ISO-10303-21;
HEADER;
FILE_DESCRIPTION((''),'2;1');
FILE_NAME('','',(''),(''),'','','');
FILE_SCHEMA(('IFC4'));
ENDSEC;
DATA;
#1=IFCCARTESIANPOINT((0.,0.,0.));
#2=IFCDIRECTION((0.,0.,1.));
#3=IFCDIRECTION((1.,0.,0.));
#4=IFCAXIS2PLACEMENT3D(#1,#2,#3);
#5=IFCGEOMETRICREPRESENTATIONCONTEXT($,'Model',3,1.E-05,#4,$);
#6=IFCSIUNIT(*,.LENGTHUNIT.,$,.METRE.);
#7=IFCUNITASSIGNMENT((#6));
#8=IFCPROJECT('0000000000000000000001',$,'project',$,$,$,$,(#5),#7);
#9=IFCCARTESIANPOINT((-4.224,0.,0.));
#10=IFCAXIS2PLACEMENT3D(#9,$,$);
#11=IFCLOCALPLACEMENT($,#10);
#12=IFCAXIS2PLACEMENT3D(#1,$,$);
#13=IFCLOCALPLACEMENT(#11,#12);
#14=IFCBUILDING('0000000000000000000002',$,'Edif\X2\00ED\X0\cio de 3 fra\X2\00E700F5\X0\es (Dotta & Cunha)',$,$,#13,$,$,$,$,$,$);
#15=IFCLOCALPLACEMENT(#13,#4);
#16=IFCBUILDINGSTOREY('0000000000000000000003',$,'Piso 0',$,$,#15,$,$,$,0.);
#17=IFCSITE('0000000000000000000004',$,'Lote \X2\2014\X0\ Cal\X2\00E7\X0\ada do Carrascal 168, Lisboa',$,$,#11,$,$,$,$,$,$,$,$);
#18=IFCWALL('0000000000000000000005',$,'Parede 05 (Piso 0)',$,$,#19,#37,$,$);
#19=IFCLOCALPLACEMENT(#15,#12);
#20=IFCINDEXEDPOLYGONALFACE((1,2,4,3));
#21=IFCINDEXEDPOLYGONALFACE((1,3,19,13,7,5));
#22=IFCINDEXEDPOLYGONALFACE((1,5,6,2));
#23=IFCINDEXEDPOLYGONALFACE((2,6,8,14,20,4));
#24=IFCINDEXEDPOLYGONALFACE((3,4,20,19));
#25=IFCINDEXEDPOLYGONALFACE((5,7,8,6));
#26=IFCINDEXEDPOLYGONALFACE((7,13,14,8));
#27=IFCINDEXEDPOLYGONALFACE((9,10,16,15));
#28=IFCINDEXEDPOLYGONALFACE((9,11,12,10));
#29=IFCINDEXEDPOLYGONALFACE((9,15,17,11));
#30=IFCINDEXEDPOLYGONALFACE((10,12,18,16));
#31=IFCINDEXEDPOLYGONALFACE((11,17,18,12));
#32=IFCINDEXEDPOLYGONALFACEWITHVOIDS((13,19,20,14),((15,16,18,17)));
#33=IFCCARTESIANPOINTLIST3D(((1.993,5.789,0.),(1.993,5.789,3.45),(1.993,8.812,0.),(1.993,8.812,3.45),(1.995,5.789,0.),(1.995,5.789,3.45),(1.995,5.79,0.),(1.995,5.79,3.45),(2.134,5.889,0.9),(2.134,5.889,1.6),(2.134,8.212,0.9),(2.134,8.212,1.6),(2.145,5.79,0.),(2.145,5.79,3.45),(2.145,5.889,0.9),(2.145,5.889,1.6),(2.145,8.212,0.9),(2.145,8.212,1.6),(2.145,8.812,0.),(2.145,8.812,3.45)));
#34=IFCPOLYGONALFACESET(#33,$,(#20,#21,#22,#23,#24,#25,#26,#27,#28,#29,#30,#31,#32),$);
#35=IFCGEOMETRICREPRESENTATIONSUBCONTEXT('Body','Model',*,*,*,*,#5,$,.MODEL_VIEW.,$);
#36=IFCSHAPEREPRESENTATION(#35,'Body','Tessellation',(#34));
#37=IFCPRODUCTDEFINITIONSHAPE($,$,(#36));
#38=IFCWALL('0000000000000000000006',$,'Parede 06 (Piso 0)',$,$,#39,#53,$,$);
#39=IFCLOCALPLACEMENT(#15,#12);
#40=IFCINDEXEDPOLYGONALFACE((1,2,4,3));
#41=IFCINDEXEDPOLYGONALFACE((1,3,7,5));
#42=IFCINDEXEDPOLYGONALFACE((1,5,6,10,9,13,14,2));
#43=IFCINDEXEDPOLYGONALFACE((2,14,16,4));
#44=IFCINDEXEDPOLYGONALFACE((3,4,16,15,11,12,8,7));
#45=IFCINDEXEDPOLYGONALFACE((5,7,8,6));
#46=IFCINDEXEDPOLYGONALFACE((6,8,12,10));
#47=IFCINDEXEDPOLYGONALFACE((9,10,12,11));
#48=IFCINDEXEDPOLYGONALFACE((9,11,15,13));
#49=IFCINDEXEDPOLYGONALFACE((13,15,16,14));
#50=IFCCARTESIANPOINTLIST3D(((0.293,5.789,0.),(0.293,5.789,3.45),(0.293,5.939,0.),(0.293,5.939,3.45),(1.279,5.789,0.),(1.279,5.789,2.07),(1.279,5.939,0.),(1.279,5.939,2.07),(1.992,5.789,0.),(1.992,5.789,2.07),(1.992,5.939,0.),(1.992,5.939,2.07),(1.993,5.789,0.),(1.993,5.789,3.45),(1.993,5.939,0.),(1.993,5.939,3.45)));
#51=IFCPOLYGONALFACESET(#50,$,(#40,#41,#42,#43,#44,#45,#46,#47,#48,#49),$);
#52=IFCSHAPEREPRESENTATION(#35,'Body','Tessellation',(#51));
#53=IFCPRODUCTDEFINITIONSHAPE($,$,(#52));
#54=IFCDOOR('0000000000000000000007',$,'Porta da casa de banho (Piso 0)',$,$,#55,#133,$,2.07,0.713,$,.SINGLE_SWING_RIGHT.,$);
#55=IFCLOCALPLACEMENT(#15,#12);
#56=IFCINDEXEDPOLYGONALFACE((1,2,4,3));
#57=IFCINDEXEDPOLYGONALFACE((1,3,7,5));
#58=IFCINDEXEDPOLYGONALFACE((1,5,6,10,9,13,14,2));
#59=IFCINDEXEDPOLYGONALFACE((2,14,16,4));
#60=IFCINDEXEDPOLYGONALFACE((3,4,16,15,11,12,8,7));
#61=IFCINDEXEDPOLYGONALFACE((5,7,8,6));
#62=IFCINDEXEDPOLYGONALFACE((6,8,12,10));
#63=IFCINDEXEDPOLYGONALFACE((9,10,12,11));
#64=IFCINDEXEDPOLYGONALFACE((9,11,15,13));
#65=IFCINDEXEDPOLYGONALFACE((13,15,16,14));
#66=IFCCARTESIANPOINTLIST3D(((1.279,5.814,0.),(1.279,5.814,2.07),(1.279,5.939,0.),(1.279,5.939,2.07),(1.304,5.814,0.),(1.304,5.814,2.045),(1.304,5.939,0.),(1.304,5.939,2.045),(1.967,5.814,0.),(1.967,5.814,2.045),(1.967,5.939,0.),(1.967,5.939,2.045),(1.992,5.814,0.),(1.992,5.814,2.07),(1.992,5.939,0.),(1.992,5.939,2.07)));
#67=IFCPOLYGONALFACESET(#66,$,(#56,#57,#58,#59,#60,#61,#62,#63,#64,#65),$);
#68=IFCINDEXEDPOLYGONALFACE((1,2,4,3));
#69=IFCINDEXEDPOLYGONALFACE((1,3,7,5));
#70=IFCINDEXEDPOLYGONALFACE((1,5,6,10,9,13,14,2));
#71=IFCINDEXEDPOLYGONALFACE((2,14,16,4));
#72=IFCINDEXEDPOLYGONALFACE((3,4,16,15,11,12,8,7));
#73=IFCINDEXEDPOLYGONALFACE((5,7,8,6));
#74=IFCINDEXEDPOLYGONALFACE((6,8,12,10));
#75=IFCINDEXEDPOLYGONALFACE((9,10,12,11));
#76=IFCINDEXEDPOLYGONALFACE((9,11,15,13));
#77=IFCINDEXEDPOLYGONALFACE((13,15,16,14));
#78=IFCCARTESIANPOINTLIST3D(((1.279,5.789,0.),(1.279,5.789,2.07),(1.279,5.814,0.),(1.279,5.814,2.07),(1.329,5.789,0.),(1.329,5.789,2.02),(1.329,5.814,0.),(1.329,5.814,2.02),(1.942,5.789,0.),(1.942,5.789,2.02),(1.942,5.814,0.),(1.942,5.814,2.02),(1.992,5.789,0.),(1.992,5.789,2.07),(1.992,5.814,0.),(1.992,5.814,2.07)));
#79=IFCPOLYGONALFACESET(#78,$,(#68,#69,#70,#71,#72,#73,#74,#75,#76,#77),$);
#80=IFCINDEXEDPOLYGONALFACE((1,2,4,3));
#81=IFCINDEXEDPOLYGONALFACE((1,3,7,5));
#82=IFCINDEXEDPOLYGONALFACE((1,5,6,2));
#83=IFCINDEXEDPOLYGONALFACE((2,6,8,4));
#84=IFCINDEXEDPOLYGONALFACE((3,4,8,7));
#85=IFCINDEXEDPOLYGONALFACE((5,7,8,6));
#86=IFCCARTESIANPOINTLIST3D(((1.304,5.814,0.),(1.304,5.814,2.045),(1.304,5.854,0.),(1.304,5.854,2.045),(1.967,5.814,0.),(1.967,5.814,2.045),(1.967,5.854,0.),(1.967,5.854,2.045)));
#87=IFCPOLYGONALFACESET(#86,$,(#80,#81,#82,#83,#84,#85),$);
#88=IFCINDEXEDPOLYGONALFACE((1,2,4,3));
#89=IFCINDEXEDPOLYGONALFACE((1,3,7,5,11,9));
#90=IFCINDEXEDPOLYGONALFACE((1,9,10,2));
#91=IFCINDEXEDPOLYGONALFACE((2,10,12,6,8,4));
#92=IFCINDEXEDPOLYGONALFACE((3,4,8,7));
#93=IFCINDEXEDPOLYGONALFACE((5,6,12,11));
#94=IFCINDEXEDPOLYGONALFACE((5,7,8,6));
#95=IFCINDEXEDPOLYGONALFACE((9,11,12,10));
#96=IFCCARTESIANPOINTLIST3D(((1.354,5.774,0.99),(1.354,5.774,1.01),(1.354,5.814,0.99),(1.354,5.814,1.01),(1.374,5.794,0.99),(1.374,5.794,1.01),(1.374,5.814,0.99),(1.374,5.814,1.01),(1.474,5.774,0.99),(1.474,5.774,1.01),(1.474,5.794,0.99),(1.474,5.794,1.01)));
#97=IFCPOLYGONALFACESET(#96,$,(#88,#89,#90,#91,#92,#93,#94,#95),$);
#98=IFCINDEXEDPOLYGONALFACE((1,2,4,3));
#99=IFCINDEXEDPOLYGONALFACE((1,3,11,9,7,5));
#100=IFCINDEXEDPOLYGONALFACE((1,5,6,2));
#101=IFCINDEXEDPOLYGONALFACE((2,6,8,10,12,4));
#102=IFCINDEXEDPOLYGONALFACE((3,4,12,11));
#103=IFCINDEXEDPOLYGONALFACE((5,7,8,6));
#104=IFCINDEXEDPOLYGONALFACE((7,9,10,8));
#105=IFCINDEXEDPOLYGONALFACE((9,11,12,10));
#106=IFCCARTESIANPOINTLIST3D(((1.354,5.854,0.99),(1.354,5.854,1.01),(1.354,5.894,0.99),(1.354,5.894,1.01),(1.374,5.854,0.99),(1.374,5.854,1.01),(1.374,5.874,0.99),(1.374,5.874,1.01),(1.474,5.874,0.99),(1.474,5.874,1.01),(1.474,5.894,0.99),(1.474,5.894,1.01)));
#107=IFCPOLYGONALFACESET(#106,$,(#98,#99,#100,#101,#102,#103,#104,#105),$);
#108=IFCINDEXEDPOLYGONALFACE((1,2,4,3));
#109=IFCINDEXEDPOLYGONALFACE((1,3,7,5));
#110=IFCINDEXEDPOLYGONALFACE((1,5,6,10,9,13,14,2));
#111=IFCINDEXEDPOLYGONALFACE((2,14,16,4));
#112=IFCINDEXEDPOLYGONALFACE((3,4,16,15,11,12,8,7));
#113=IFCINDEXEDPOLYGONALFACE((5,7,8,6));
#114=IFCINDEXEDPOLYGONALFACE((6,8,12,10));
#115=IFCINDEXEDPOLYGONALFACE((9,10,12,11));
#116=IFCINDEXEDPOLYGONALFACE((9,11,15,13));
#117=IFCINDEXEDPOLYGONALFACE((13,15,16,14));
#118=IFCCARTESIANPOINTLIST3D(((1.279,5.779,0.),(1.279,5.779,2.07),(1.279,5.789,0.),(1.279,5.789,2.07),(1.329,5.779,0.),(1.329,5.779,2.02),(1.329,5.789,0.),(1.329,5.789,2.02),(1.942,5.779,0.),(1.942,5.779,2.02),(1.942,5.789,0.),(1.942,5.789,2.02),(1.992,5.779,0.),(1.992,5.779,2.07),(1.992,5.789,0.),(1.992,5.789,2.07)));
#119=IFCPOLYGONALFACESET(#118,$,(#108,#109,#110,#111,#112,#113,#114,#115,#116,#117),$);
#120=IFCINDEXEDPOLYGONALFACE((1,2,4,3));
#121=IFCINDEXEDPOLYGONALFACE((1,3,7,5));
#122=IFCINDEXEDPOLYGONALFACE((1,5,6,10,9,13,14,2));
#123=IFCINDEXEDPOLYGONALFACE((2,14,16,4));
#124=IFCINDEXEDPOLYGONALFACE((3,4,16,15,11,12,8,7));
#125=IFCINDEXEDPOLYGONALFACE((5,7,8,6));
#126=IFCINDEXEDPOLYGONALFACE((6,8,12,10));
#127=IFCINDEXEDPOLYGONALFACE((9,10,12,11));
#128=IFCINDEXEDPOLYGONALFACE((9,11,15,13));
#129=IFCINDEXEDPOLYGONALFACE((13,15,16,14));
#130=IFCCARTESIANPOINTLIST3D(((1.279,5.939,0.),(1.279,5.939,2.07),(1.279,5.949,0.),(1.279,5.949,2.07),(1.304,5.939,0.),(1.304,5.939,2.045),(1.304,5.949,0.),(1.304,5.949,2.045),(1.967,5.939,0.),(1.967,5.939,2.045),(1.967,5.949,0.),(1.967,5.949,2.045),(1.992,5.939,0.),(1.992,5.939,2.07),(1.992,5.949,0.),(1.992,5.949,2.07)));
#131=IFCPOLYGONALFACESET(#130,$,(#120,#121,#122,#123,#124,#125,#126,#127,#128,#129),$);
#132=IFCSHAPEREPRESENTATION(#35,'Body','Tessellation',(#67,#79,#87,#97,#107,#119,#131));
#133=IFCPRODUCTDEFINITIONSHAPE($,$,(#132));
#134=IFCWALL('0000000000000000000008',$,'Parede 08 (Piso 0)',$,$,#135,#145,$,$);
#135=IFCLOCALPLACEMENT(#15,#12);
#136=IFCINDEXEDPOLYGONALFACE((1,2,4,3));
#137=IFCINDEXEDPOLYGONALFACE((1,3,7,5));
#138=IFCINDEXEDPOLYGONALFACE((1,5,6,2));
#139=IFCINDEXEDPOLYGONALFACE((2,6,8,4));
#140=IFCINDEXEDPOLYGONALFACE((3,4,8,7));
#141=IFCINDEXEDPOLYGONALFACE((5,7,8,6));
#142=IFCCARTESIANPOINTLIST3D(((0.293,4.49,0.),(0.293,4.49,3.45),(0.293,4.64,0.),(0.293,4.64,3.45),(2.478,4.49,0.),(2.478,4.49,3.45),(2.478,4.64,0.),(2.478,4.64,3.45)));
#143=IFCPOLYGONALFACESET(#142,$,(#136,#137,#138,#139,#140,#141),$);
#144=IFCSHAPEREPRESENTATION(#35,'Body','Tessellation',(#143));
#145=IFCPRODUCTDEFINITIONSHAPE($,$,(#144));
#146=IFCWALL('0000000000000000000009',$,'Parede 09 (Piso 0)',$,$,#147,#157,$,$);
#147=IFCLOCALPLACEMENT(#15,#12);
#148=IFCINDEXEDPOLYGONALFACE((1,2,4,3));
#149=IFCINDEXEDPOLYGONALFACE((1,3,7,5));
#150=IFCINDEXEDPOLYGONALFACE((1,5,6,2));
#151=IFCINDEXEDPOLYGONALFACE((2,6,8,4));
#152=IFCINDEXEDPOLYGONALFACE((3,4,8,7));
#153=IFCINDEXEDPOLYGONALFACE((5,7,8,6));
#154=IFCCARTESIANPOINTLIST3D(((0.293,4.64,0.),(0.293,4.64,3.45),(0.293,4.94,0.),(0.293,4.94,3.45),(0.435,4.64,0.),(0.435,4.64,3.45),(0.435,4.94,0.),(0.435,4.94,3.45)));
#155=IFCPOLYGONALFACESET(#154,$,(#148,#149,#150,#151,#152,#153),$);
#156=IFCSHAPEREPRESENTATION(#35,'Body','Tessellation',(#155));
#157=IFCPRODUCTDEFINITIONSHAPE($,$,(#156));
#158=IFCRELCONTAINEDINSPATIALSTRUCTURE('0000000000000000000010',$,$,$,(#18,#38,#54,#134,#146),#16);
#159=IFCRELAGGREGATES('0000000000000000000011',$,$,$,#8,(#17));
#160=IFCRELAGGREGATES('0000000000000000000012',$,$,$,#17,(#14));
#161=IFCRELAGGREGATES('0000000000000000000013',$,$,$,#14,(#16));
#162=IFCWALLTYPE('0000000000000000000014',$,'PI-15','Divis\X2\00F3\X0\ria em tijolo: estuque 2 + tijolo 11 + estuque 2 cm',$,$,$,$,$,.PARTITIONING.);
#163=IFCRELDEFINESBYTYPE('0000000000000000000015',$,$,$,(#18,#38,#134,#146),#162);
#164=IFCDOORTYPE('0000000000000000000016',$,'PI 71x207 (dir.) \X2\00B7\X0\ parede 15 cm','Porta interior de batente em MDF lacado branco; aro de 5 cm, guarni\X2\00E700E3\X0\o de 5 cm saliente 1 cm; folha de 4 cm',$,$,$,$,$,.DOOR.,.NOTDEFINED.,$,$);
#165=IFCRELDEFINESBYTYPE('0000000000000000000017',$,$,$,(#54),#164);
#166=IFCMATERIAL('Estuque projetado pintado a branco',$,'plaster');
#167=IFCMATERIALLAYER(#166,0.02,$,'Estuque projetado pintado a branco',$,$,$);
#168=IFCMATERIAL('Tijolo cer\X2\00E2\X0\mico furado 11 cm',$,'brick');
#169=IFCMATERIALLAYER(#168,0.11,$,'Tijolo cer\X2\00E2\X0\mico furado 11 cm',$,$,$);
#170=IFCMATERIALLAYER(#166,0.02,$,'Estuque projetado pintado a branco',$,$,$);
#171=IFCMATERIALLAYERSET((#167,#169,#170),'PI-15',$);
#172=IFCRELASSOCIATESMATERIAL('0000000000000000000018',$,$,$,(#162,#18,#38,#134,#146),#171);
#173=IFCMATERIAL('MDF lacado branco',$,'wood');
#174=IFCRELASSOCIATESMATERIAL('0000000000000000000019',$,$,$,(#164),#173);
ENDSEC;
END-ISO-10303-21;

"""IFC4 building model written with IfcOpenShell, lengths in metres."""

from ifc_helpers import new_model, si_unit, frame, origin, origin_with_axes, place, context, subcontext, project, spatial, line, indexed_curve, outline, extrude, source, transform, mapped, material, layer, layer_set, layer_usage, type_object, type_shapes, element, fill, save


model = new_model("IFC4")

# Units and contexts
model_context = context("Model", 3, precision=1e-05, world=origin_with_axes())
body_context = subcontext(model_context, "Body", "Model", "MODEL_VIEW")
ifc_project = project(units=[si_unit("LENGTHUNIT", "METRE")], contexts=[model_context])

# Site, building, storey
site_placement = place(None, frame((-4.224, 0.0, 0.0)))
site = spatial("IfcSite", under=ifc_project, at=site_placement, Name="Lote — Calçada do Carrascal 168, Lisboa")
building_placement = place(site_placement, origin())
building = spatial("IfcBuilding", under=site, at=building_placement, Name="Edifício de 3 frações (Dotta & Cunha)")
storey_placement = place(building_placement, origin_with_axes())
storey = spatial("IfcBuildingStorey", under=building, at=storey_placement, Name="Piso 0", Elevation=0.0)

# Wall, opening
ifc_material_1 = material(Name="Estuque projetado pintado a branco", Category="plaster")
ifc_layer_1 = layer(ifc_material_1, 0.02, Name="Estuque projetado pintado a branco")
ifc_material_2 = material(Name="Tijolo cerâmico furado 11 cm", Category="brick")
ifc_layer_2 = layer(ifc_material_2, 0.11, Name="Tijolo cerâmico furado 11 cm")
ifc_layer_3 = layer(ifc_material_1, 0.02, Name="Estuque projetado pintado a branco")
ifc_layer_set_1 = layer_set([ifc_layer_1, ifc_layer_2, ifc_layer_3], Name="PI-15")
ifc_layer_usage_1 = layer_usage(ifc_layer_set_1, "AXIS2", "POSITIVE", 0.0)
wall_type_1 = type_object("IfcWallType", Name="PI-15", Description="Divisória em tijolo: estuque 2 + tijolo 11 + estuque 2 cm", PredefinedType="PARTITIONING", material=ifc_layer_set_1)
wall_1_placement = place(storey_placement, origin_with_axes())
wall_1 = element("IfcWall", 1, at=wall_1_placement, inside=storey, type_object=wall_type_1, material=ifc_layer_usage_1, Name="Parede 05 (Piso 0)", context=body_context, shape_type="SweptSolid", body=[
    extrude(outline(indexed_curve([(1.995, 5.789), (1.993, 5.789), (1.993, 5.79), (1.993, 8.812), (2.145, 8.812), (2.145, 5.79), (1.995, 5.79)], segments=[line(1, 2, 3, 4, 5, 6, 7, 1)])), origin_with_axes(), (0.0, 0.0, 1.0), 3.45),
])
opening_1_placement = place(wall_1_placement, frame((0.0, 0.0, 0.9), z_axis=(0.0, 0.0, 1.0), x_axis=(1.0, 0.0, 0.0)))
element("IfcOpeningElement", 2, at=opening_1_placement, cuts=wall_1, PredefinedType="RECESS", context=body_context, shape_type="SweptSolid", body=[
    extrude(outline(indexed_curve([(2.15, 5.889), (2.15, 8.212), (2.134, 8.212), (2.134, 5.889)], segments=[line(1, 2, 3, 4, 1)])), origin_with_axes(), (0.0, 0.0, 1.0), 0.7),
])

# Wall, opening, door
ifc_layer_usage_2 = layer_usage(ifc_layer_set_1, "AXIS2", "POSITIVE", 0.0)
wall_2_placement = place(storey_placement, origin_with_axes())
wall_2 = element("IfcWall", 3, at=wall_2_placement, inside=storey, type_object=wall_type_1, material=ifc_layer_usage_2, Name="Parede 06 (Piso 0)", context=body_context, shape_type="SweptSolid", body=[
    extrude(outline(indexed_curve([(1.993, 5.789), (1.993, 5.939), (0.293, 5.939), (0.293, 5.789)], segments=[line(1, 2, 3, 4, 1)])), origin_with_axes(), (0.0, 0.0, 1.0), 3.45),
])
opening_2_placement = place(wall_2_placement, origin_with_axes())
opening_2 = element("IfcOpeningElement", 4, at=opening_2_placement, cuts=wall_2, context=body_context, shape_type="SweptSolid", body=[
    extrude(outline(indexed_curve([(1.992, 5.787), (1.992, 5.941), (1.279, 5.941), (1.279, 5.787)], segments=[line(1, 2, 3, 4, 1)])), origin_with_axes(), (0.0, 0.0, 1.0), 2.07),
])
ifc_material_3 = material(Name="MDF lacado branco", Category="wood")
door_type = type_object("IfcDoorType", Name="PI 71x207 (dir.) · parede 15 cm", Description="Porta interior de batente em MDF lacado branco; aro de 5 cm, guarnição de 5 cm saliente 1 cm; folha de 4 cm", OperationType="NOTDEFINED", PredefinedType="DOOR", material=ifc_material_3)
shared_shape = source(origin_with_axes(), body_context, "Body", "SweptSolid", [
    extrude(outline(indexed_curve([(0.0, 0.0), (0.0, 2.07), (0.713, 2.07), (0.713, 0.0), (0.688, 0.0), (0.688, 2.045), (0.025, 2.045), (0.025, 0.0)], segments=[line(1, 2, 3, 4, 5, 6, 7, 8, 1)])), frame((0.0, 0.025, 0.0), z_axis=(0.0, -1.0, 0.0), x_axis=(1.0, 0.0, 0.0)), (0.0, 0.0, -1.0), 0.125),
    extrude(outline(indexed_curve([(0.0, 0.0), (0.0, 2.07), (0.713, 2.07), (0.713, 0.0), (0.663, 0.0), (0.663, 2.02), (0.05, 2.02), (0.05, 0.0)], segments=[line(1, 2, 3, 4, 5, 6, 7, 8, 1)])), frame((0.0, 0.0, 0.0), z_axis=(0.0, -1.0, 0.0), x_axis=(1.0, 0.0, 0.0)), (0.0, 0.0, -1.0), 0.025),
    extrude(outline(indexed_curve([(0.0, 0.0), (0.663, 0.0), (0.663, 0.04), (0.0, 0.04)], segments=[line(1, 2, 3, 4, 1)])), frame((0.025, 0.025, 0.0), z_axis=(0.0, 0.0, 1.0), x_axis=(1.0, 0.0, 0.0)), (0.0, 0.0, 1.0), 2.045),
    extrude(outline(indexed_curve([(0.0, 0.0), (0.0, -0.04), (0.12, -0.04), (0.12, -0.02), (0.02, -0.02), (0.02, 0.0)], segments=[line(1, 2, 3, 4, 5, 6, 1)])), frame((0.075, 0.025, 0.99), z_axis=(0.0, 0.0, 1.0), x_axis=(1.0, 0.0, 0.0)), (0.0, 0.0, 1.0), 0.02),
    extrude(outline(indexed_curve([(0.0, 0.0), (0.0, 0.04), (0.12, 0.04), (0.12, 0.02), (0.02, 0.02), (0.02, 0.0)], segments=[line(1, 2, 3, 4, 5, 6, 1)])), frame((0.075, 0.065, 0.99), z_axis=(0.0, 0.0, 1.0), x_axis=(1.0, 0.0, 0.0)), (0.0, 0.0, 1.0), 0.02),
    extrude(outline(indexed_curve([(0.0, 0.0), (0.0, 2.07), (0.713, 2.07), (0.713, 0.0), (0.663, 0.0), (0.663, 2.02), (0.05, 2.02), (0.05, 0.0)], segments=[line(1, 2, 3, 4, 5, 6, 7, 8, 1)])), frame((0.0, -0.01, 0.0), z_axis=(0.0, -1.0, 0.0), x_axis=(1.0, 0.0, 0.0)), (0.0, 0.0, -1.0), 0.01),
    extrude(outline(indexed_curve([(0.0, 0.0), (0.0, 2.07), (0.713, 2.07), (0.713, 0.0), (0.688, 0.0), (0.688, 2.045), (0.025, 2.045), (0.025, 0.0)], segments=[line(1, 2, 3, 4, 5, 6, 7, 8, 1)])), frame((0.0, 0.15, 0.0), z_axis=(0.0, -1.0, 0.0), x_axis=(1.0, 0.0, 0.0)), (0.0, 0.0, -1.0), 0.01),
])
type_shapes(door_type, [shared_shape])
door_placement = place(storey_placement, frame((1.279, 5.789, 0.0), z_axis=(0.0, 0.0, 1.0), x_axis=(1.0, 0.0, 0.0)))
door = element("IfcDoor", 5, at=door_placement, inside=storey, type_object=door_type, Name="Porta da casa de banho (Piso 0)", OperationType="SINGLE_SWING_RIGHT", OverallHeight=2.07, OverallWidth=0.713, context=body_context, shape_type="MappedRepresentation", body=[
    mapped(shared_shape, transform((0.0, 0.0, 0.0), x_axis=(1.0, 0.0, 0.0), y_axis=(0.0, 1.0, 0.0), z_axis=(0.0, 0.0, 1.0), scale=1.0)),
])
fill(opening_2, door)

# Walls
ifc_layer_usage_3 = layer_usage(ifc_layer_set_1, "AXIS2", "POSITIVE", 0.0)
wall_3_placement = place(storey_placement, origin_with_axes())
element("IfcWall", 6, at=wall_3_placement, inside=storey, type_object=wall_type_1, material=ifc_layer_usage_3, Name="Parede 08 (Piso 0)", context=body_context, shape_type="SweptSolid", body=[
    extrude(outline(indexed_curve([(2.478, 4.49), (2.478, 4.64), (0.293, 4.64), (0.293, 4.49)], segments=[line(1, 2, 3, 4, 1)])), origin_with_axes(), (0.0, 0.0, 1.0), 3.45),
])
ifc_layer_usage_4 = layer_usage(ifc_layer_set_1, "AXIS2", "POSITIVE", 0.0)
wall_4_placement = place(storey_placement, origin_with_axes())
element("IfcWall", 7, at=wall_4_placement, inside=storey, type_object=wall_type_1, material=ifc_layer_usage_4, Name="Parede 09 (Piso 0)", context=body_context, shape_type="SweptSolid", body=[
    extrude(outline(indexed_curve([(0.435, 4.64), (0.435, 4.94), (0.293, 4.94), (0.293, 4.64)], segments=[line(1, 2, 3, 4, 1)])), origin_with_axes(), (0.0, 0.0, 1.0), 3.45),
])

save(model, "model.ifc")
